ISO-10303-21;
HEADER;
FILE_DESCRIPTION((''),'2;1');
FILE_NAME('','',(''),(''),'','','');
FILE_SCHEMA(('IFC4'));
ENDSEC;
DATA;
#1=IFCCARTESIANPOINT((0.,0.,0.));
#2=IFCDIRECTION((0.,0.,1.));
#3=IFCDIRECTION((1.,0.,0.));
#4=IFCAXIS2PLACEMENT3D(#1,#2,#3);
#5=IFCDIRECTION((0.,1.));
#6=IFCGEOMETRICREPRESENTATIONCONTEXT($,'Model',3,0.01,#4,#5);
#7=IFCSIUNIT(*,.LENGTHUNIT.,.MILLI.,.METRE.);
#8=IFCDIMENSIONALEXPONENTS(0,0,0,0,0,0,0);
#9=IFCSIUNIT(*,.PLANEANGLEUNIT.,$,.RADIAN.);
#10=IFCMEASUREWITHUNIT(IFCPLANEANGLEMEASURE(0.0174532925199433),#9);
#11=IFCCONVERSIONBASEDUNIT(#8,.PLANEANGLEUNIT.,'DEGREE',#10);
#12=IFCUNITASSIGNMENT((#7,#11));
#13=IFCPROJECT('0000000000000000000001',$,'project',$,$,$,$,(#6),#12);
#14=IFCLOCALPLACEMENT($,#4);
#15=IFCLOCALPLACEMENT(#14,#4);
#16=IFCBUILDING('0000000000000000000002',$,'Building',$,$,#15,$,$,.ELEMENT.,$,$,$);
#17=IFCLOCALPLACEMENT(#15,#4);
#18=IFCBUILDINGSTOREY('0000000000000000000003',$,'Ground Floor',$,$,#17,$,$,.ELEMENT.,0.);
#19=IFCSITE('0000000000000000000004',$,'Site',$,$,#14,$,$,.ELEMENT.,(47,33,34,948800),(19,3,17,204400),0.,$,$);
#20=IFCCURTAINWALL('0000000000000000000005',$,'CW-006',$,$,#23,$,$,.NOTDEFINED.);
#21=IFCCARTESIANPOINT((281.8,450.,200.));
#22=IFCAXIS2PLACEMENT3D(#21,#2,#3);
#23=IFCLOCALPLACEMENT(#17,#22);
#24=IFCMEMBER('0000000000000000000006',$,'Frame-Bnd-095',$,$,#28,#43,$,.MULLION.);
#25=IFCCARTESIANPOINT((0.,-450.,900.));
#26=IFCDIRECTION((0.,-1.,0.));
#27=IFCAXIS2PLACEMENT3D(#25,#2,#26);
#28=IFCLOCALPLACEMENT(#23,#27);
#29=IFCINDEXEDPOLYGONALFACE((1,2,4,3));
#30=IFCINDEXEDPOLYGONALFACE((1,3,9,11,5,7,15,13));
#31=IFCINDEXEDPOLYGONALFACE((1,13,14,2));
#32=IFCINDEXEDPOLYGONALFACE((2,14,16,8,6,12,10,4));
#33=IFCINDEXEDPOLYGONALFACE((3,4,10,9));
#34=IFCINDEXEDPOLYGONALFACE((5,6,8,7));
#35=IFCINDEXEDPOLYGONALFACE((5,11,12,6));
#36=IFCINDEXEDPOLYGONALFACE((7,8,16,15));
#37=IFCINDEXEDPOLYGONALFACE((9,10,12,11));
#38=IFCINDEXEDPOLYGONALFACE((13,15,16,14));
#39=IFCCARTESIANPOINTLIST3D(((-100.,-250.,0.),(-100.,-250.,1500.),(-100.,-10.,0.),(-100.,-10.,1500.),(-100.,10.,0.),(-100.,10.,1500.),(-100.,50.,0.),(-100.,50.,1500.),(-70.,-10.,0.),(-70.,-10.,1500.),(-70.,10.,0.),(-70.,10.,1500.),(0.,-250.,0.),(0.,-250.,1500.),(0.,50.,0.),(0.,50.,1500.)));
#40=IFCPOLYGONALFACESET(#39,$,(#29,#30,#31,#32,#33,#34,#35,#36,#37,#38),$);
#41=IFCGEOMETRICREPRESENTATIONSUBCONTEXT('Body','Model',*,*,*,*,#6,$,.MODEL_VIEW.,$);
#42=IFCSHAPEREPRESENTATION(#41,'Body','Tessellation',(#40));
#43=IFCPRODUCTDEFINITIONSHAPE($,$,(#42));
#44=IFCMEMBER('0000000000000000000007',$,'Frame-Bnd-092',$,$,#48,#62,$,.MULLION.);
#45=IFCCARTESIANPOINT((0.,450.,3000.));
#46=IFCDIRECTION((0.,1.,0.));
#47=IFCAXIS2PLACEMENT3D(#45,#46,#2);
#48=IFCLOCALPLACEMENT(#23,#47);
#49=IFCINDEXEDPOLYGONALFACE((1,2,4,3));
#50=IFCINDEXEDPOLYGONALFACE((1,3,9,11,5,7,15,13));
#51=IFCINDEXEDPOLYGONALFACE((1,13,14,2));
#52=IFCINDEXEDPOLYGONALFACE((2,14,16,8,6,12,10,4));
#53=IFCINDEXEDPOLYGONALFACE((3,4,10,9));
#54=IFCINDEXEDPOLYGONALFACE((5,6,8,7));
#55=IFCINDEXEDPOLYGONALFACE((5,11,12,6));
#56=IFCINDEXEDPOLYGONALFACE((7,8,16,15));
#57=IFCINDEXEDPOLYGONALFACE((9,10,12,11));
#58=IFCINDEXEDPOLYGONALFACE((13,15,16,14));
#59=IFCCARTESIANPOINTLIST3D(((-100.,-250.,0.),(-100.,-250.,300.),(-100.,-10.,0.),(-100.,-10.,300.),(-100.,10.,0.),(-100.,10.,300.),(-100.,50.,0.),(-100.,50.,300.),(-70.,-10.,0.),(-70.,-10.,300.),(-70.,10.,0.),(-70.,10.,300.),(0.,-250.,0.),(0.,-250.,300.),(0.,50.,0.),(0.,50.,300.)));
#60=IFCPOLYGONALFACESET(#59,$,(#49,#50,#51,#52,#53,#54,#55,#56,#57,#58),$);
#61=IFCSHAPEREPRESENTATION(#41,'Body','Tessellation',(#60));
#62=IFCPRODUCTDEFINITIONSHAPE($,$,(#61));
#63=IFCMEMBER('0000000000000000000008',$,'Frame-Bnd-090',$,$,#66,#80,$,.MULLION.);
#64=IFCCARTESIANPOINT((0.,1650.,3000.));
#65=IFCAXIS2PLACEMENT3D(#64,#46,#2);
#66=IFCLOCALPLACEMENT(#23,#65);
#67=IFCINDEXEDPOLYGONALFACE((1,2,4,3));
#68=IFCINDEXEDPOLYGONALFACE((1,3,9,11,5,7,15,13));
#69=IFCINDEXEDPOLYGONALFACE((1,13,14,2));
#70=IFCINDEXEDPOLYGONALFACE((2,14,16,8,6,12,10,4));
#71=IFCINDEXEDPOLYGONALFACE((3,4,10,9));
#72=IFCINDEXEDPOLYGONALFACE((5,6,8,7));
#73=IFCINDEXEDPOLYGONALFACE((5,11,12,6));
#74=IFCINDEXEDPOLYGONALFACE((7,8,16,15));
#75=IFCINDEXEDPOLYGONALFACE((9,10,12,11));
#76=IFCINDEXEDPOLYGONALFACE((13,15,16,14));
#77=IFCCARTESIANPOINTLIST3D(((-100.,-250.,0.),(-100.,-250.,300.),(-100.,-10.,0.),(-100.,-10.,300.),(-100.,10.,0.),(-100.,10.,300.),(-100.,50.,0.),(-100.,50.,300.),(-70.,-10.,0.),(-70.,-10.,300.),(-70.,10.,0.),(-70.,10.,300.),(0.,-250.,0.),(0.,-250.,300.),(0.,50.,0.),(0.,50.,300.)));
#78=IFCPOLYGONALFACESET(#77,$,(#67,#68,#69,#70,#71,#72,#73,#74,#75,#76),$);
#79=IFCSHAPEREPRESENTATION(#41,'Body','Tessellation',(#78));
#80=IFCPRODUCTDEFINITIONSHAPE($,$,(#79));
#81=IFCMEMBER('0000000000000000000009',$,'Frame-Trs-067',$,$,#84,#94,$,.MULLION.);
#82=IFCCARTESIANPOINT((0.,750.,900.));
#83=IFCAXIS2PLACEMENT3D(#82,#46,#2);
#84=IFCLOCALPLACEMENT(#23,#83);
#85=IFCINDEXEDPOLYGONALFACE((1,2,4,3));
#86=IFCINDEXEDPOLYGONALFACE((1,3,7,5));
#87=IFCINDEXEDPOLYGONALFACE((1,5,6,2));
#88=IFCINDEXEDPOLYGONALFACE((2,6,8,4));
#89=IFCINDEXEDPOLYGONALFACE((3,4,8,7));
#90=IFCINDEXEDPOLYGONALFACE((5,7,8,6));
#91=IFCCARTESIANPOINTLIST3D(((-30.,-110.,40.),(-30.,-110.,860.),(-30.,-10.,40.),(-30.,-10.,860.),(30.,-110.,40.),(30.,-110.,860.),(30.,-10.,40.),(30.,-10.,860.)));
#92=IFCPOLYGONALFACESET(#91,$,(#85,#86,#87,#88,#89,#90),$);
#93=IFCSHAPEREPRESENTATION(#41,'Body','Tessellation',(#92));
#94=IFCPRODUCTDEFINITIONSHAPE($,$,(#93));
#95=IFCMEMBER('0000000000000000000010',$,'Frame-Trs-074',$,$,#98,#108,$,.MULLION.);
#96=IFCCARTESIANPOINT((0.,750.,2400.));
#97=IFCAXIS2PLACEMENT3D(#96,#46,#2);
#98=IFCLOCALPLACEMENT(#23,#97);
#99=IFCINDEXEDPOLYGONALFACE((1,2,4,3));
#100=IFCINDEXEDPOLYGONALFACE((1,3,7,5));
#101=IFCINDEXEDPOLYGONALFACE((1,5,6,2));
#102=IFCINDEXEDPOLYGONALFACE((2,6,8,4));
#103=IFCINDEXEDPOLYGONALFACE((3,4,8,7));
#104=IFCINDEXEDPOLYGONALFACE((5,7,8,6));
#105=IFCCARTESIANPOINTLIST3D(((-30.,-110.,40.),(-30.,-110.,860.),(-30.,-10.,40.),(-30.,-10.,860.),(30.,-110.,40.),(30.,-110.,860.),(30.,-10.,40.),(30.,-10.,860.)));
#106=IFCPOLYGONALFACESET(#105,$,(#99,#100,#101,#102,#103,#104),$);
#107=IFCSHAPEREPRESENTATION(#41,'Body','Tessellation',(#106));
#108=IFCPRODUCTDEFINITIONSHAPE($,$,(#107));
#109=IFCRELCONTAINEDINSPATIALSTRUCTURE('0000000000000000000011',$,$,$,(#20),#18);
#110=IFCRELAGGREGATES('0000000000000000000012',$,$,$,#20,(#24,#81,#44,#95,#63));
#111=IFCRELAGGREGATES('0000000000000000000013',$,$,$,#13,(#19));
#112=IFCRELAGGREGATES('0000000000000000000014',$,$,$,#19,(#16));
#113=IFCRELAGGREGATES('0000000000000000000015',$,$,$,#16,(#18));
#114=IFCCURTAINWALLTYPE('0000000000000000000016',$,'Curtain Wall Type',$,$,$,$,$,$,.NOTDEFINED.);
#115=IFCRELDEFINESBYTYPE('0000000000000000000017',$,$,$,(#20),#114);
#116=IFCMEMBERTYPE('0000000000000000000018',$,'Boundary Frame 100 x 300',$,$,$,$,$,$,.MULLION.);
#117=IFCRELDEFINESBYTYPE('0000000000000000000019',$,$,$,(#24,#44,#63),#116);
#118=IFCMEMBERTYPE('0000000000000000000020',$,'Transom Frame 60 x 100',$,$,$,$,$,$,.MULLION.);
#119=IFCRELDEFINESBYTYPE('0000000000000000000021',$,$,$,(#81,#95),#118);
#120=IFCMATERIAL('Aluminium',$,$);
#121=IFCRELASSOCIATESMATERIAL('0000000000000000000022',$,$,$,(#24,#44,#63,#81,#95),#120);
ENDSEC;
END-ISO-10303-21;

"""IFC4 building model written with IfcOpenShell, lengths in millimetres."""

from ifc_helpers import new_model, entity, si_unit, converted_unit, direction, frame, frame_2d, origin_with_axes, place, context, subcontext, project, spatial, line, indexed_curve, rectangle, outline, extrude, material, type_object, element, aggregate, save


model = new_model("IFC4")

# Units and contexts
model_context = context("Model", 3, precision=0.01, world=origin_with_axes(), true_north=direction((0.0, 1.0)))
body_context = subcontext(model_context, "Body", "Model", "MODEL_VIEW")
ifc_project = project(units=[si_unit("LENGTHUNIT", "METRE", prefix="MILLI"), converted_unit("PLANEANGLEUNIT", "DEGREE", entity("IfcPlaneAngleMeasure", 0.0174532925199433), si_unit("PLANEANGLEUNIT", "RADIAN"), dimensions=[0, 0, 0, 0, 0, 0, 0])], contexts=[model_context])

# Site, building, storey
site_placement = place(None, origin_with_axes())
site = spatial("IfcSite", under=ifc_project, at=site_placement, Name="Site", CompositionType="ELEMENT", RefLatitude=(47, 33, 34, 948800), RefLongitude=(19, 3, 17, 204400), RefElevation=0.0)
building_placement = place(site_placement, origin_with_axes())
building = spatial("IfcBuilding", under=site, at=building_placement, Name="Building", CompositionType="ELEMENT")
storey_placement = place(building_placement, origin_with_axes())
storey = spatial("IfcBuildingStorey", under=building, at=storey_placement, Name="Ground Floor", CompositionType="ELEMENT", Elevation=0.0)

# Curtain wall, members
curtain_wall_type = type_object("IfcCurtainWallType", Name="Curtain Wall Type", PredefinedType="NOTDEFINED")
curtain_wall_placement = place(storey_placement, frame((281.8, 450.0, 200.0), z_axis=(0.0, 0.0, 1.0), x_axis=(1.0, 0.0, 0.0)))
curtain_wall = element("IfcCurtainWall", 1, at=curtain_wall_placement, inside=storey, type_object=curtain_wall_type, Name="CW-006", PredefinedType="NOTDEFINED")
ifc_material_1 = material(Name="Aluminium")
member_type_1 = type_object("IfcMemberType", Name="Boundary Frame 100 x 300", PredefinedType="MULLION")
member_1_placement = place(curtain_wall_placement, frame((0.0, -450.0, 900.0), z_axis=(0.0, 0.0, 1.0), x_axis=(0.0, -1.0, 0.0)))
member_1 = element("IfcMember", 2, at=member_1_placement, type_object=member_type_1, material=ifc_material_1, Name="Frame-Bnd-095", PredefinedType="MULLION", context=body_context, shape_type="SweptSolid", body=[
    extrude(outline(indexed_curve([(-70.0, -10.0), (-100.0, -10.0), (-100.0, -250.0), (0.0, -250.0), (0.0, 50.0), (-100.0, 50.0), (-100.0, 10.0), (-70.0, 10.0)], segments=[line(1, 2, 3, 4, 5, 6, 7, 8, 1)])), origin_with_axes(), (0.0, 0.0, 1.0), 1500.0),
])
member_2_placement = place(curtain_wall_placement, frame((0.0, 450.0, 3000.0), z_axis=(0.0, 1.0, 0.0), x_axis=(0.0, 0.0, 1.0)))
member_2 = element("IfcMember", 3, at=member_2_placement, type_object=member_type_1, material=ifc_material_1, Name="Frame-Bnd-092", PredefinedType="MULLION", context=body_context, shape_type="SweptSolid", body=[
    extrude(outline(indexed_curve([(-70.0, -10.0), (-100.0, -10.0), (-100.0, -250.0), (0.0, -250.0), (0.0, 50.0), (-100.0, 50.0), (-100.0, 10.0), (-70.0, 10.0)], segments=[line(1, 2, 3, 4, 5, 6, 7, 8, 1)])), origin_with_axes(), (0.0, 0.0, 1.0), 300.0),
])
member_3_placement = place(curtain_wall_placement, frame((0.0, 1650.0, 3000.0), z_axis=(0.0, 1.0, 0.0), x_axis=(0.0, 0.0, 1.0)))
member_3 = element("IfcMember", 4, at=member_3_placement, type_object=member_type_1, material=ifc_material_1, Name="Frame-Bnd-090", PredefinedType="MULLION", context=body_context, shape_type="SweptSolid", body=[
    extrude(outline(indexed_curve([(-70.0, -10.0), (-100.0, -10.0), (-100.0, -250.0), (0.0, -250.0), (0.0, 50.0), (-100.0, 50.0), (-100.0, 10.0), (-70.0, 10.0)], segments=[line(1, 2, 3, 4, 5, 6, 7, 8, 1)])), origin_with_axes(), (0.0, 0.0, 1.0), 300.0),
])
member_type_2 = type_object("IfcMemberType", Name="Transom Frame 60 x 100", PredefinedType="MULLION")
member_4_placement = place(curtain_wall_placement, frame((0.0, 750.0, 900.0), z_axis=(0.0, 1.0, 0.0), x_axis=(0.0, 0.0, 1.0)))
member_4 = element("IfcMember", 5, at=member_4_placement, type_object=member_type_2, material=ifc_material_1, Name="Frame-Trs-067", PredefinedType="MULLION", context=body_context, shape_type="SweptSolid", body=[
    extrude(rectangle(XDim=100.0, YDim=60.0, at=frame_2d((0.0, -60.0), x_axis=(0.0, 1.0))), frame((0.0, 0.0, 40.0), z_axis=(0.0, 0.0, 1.0), x_axis=(1.0, 0.0, 0.0)), (0.0, 0.0, 1.0), 820.0),
])
member_5_placement = place(curtain_wall_placement, frame((0.0, 750.0, 2400.0), z_axis=(0.0, 1.0, 0.0), x_axis=(0.0, 0.0, 1.0)))
member_5 = element("IfcMember", 6, at=member_5_placement, type_object=member_type_2, material=ifc_material_1, Name="Frame-Trs-074", PredefinedType="MULLION", context=body_context, shape_type="SweptSolid", body=[
    extrude(rectangle(XDim=100.0, YDim=60.0, at=frame_2d((0.0, -60.0), x_axis=(0.0, 1.0))), frame((0.0, 0.0, 40.0), z_axis=(0.0, 0.0, 1.0), x_axis=(1.0, 0.0, 0.0)), (0.0, 0.0, 1.0), 820.0),
])

aggregate(curtain_wall, [member_1, member_4, member_2, member_5, member_3])

save(model, "model.ifc")
